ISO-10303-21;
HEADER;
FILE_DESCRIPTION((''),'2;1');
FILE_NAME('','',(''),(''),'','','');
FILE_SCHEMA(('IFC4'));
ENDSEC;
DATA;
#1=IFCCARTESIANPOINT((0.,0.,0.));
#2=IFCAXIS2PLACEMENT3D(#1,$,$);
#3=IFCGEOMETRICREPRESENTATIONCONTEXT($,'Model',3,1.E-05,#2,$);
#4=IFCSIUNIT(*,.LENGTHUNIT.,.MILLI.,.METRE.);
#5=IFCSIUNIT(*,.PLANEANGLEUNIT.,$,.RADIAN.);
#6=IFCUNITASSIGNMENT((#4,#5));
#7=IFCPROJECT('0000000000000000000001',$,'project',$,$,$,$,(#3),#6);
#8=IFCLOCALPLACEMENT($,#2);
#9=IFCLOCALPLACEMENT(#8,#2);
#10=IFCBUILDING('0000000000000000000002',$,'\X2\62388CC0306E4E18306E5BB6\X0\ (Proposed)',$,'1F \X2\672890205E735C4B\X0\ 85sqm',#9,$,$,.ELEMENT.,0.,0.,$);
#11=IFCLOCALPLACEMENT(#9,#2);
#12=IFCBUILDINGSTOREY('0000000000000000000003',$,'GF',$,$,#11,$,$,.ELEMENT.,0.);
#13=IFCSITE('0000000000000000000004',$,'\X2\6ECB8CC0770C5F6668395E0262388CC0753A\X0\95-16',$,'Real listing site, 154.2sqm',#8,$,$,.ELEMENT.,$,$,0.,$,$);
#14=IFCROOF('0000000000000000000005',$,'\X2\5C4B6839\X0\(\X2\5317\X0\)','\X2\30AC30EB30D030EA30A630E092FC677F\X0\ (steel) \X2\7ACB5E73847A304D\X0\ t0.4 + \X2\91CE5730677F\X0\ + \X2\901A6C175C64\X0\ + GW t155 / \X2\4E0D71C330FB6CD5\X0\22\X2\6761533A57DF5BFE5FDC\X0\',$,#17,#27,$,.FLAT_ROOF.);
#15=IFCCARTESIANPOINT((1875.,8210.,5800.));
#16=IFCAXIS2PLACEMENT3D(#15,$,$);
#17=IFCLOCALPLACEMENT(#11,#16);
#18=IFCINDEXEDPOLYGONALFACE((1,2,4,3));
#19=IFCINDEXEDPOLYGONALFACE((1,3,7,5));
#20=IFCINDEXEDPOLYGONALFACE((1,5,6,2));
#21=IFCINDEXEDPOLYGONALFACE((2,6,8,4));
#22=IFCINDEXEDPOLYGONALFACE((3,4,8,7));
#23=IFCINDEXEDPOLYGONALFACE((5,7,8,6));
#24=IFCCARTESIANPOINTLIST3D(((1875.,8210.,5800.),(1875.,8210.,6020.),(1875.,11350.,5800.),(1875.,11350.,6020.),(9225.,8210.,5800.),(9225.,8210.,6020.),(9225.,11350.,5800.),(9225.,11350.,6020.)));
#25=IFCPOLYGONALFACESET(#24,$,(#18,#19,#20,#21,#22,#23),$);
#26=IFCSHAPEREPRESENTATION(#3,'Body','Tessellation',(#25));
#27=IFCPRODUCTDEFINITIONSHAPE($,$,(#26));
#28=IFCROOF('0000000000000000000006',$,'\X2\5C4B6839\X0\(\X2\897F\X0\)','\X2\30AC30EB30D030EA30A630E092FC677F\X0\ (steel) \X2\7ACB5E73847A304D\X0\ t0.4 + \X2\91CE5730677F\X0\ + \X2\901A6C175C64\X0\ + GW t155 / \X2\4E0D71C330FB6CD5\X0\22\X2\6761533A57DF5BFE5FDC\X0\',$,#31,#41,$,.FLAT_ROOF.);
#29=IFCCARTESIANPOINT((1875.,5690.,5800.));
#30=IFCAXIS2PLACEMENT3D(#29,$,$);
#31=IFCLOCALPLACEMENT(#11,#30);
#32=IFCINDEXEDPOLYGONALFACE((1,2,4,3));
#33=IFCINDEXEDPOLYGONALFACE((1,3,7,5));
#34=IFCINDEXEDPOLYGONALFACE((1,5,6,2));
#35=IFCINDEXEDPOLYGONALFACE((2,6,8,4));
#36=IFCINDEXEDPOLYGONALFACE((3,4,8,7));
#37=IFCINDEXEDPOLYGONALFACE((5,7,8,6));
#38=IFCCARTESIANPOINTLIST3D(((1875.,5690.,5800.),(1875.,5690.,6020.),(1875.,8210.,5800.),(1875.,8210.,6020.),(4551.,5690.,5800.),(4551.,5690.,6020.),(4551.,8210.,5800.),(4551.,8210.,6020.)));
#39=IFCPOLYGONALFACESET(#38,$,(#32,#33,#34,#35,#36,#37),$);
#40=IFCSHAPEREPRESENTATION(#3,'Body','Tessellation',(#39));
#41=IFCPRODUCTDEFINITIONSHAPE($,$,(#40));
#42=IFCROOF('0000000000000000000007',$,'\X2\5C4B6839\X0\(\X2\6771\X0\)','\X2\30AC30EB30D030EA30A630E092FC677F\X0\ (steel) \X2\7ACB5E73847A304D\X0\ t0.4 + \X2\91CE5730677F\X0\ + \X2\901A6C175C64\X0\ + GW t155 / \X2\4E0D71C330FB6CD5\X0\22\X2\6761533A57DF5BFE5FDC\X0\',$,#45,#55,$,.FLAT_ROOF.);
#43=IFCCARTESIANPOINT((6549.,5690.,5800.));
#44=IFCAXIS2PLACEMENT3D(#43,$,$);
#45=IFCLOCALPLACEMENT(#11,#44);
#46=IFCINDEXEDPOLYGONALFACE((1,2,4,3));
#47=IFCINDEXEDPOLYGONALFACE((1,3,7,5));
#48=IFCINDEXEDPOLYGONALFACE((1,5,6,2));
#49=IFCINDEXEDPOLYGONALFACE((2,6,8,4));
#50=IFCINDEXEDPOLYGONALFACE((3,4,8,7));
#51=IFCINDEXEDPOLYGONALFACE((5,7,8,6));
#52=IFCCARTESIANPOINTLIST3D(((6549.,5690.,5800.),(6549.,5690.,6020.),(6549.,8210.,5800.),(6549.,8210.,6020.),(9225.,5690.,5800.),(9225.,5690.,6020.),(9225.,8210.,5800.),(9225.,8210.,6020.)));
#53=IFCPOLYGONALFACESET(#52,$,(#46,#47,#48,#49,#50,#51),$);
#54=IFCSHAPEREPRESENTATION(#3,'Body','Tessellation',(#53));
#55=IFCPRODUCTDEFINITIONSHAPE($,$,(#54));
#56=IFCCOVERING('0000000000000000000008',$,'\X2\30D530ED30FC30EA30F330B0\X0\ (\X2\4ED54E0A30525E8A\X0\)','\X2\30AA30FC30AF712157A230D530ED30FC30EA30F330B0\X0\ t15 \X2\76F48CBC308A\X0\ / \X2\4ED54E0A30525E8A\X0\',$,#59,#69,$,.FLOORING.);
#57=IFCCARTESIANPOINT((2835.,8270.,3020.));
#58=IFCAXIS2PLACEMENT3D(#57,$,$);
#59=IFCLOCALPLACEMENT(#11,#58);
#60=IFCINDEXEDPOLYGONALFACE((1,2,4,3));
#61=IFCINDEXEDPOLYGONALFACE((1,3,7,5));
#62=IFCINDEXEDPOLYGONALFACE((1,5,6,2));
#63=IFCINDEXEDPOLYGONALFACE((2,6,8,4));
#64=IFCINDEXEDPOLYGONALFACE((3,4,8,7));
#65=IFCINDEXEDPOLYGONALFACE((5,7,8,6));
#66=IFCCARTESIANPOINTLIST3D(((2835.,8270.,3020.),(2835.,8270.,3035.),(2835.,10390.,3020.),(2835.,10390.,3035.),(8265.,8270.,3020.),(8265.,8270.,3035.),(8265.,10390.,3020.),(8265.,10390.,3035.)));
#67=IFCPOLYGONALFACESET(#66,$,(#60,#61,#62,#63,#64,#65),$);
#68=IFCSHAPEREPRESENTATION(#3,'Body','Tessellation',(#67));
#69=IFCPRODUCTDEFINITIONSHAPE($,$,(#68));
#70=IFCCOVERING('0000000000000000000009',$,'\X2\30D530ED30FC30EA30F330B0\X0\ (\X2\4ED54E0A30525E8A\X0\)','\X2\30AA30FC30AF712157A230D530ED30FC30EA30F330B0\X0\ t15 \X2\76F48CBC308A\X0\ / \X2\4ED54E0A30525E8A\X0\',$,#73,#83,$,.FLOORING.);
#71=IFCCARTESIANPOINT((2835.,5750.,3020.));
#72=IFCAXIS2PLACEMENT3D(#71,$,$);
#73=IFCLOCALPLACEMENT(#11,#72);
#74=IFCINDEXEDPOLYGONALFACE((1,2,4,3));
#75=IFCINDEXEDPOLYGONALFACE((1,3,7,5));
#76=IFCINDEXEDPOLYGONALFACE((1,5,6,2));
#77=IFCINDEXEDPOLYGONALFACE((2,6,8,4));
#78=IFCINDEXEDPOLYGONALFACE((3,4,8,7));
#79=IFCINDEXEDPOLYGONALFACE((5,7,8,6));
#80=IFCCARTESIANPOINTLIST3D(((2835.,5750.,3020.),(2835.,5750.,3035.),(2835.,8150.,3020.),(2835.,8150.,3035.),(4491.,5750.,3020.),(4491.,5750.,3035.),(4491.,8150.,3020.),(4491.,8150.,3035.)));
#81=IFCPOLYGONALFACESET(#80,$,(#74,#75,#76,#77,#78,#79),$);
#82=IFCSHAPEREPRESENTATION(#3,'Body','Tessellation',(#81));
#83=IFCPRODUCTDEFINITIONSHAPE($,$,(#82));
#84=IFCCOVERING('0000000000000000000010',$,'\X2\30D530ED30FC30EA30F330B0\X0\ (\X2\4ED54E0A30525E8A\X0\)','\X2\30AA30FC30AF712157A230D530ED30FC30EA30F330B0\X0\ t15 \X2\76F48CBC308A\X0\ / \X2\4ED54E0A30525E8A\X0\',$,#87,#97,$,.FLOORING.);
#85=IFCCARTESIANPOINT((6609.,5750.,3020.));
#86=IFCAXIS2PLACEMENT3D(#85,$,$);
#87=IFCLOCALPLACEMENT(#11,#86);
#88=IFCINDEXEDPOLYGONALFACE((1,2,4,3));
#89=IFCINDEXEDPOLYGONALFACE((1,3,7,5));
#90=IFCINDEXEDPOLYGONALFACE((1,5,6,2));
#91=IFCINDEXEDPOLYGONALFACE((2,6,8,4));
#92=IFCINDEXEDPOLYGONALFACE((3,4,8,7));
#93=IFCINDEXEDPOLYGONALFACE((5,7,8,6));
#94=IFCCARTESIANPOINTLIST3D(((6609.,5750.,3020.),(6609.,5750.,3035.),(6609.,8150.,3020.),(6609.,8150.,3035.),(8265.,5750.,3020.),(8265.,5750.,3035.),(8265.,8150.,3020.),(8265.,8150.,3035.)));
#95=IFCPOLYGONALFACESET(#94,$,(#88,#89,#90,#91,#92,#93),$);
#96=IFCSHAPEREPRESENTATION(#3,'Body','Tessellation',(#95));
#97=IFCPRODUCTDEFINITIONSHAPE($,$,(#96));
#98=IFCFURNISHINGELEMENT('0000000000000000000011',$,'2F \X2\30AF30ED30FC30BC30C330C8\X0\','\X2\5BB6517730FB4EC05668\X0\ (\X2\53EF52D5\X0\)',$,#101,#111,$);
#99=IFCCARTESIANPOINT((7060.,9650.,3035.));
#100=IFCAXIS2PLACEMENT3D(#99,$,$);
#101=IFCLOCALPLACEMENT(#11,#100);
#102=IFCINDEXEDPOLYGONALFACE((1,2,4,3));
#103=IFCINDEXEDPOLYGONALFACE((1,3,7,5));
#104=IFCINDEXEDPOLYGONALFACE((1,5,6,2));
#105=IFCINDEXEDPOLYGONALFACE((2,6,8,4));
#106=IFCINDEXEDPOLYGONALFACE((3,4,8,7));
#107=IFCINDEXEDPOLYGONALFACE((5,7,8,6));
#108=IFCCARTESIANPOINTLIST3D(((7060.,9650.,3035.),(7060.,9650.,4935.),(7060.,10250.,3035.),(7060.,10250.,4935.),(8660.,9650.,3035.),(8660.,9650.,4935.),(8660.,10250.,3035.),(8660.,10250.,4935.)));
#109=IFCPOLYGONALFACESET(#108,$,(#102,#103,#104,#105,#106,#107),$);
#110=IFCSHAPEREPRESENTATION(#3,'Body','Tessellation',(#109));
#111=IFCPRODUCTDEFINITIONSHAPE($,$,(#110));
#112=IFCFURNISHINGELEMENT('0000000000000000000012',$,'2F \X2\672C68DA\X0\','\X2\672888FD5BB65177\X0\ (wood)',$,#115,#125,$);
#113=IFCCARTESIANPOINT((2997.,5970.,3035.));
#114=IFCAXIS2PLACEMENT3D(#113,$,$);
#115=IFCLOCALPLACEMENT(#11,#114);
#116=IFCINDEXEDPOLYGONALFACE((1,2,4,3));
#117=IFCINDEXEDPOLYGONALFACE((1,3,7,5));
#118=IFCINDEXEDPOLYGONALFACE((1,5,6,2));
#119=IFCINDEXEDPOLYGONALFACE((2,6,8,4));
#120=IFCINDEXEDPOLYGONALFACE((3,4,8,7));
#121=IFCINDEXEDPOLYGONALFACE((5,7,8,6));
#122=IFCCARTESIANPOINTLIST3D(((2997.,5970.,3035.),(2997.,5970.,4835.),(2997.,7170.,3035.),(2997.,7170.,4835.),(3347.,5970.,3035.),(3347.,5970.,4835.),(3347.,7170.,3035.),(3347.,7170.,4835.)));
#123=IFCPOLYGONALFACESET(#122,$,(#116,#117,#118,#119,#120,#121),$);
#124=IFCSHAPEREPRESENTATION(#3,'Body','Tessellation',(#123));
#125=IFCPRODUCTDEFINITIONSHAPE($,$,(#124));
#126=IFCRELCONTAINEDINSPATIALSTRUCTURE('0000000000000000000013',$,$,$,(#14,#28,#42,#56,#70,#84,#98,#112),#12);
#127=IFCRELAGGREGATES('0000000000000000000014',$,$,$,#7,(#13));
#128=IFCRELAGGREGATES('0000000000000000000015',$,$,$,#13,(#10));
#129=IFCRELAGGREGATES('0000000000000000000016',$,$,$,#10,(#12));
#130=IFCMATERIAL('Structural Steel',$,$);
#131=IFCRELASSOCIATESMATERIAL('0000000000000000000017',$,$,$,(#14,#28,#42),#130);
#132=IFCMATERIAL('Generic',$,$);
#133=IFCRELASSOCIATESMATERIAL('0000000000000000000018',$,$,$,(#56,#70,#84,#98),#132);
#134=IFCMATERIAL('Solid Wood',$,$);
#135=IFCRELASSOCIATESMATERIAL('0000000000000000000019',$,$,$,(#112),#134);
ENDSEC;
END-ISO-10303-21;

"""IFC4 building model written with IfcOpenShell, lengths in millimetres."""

from ifc_helpers import new_model, si_unit, frame, frame_2d, origin, place, context, project, spatial, rectangle, extrude, material, element, save


model = new_model("IFC4")

# Units and contexts
model_context = context("Model", 3, precision=1e-05, world=origin())
ifc_project = project(units=[si_unit("LENGTHUNIT", "METRE", prefix="MILLI"), si_unit("PLANEANGLEUNIT", "RADIAN")], contexts=[model_context])

# Site, building, storey
site_placement = place(None, origin())
site = spatial("IfcSite", under=ifc_project, at=site_placement, Name="滋賀県彦根市戸賀町95-16", ObjectType="Real listing site, 154.2sqm", CompositionType="ELEMENT", RefElevation=0.0)
building_placement = place(site_placement, origin())
building = spatial("IfcBuilding", under=site, at=building_placement, Name="戸賀の丘の家 (Proposed)", ObjectType="1F 木造平屋 85sqm", CompositionType="ELEMENT", ElevationOfRefHeight=0.0, ElevationOfTerrain=0.0)
storey_placement = place(building_placement, origin())
storey = spatial("IfcBuildingStorey", under=building, at=storey_placement, Name="GF", CompositionType="ELEMENT", Elevation=0.0)

# Shared definitions
ifc_material_1 = material(Name="Solid Wood")

# Shared definitions
ifc_material_2 = material(Name="Generic")

# Roofs
ifc_material_3 = material(Name="Structural Steel")
for number, where, name in (
    (1, (1875.0, 8210.0, 5800.0), "屋根(北)"),
):
    element("IfcRoof", number, at=place(storey_placement, frame(where)), inside=storey, material=ifc_material_3, Name=name, Description="ガルバリウム鋼板 (steel) 立平葺き t0.4 + 野地板 + 通気層 + GW t155 / 不燃・法22条区域対応", PredefinedType="FLAT_ROOF", context=model_context, shape_type="SweptSolid", body=[
        extrude(rectangle(XDim=7350.0, YDim=3140.0, at=frame_2d((3675.0, 1570.0))), frame((1875.0, 8210.0, 5800.0)), (0.0, 0.0, 1.0), 220.0),
    ])
roof_1_placement = place(storey_placement, frame((1875.0, 5690.0, 5800.0)))
element("IfcRoof", 2, at=roof_1_placement, inside=storey, material=ifc_material_3, Name="屋根(西)", Description="ガルバリウム鋼板 (steel) 立平葺き t0.4 + 野地板 + 通気層 + GW t155 / 不燃・法22条区域対応", PredefinedType="FLAT_ROOF", context=model_context, shape_type="SweptSolid", body=[
    extrude(rectangle(XDim=2676.0, YDim=2520.0, at=frame_2d((1338.0, 1260.0))), frame((1875.0, 5690.0, 5800.0)), (0.0, 0.0, 1.0), 220.0),
])
roof_2_placement = place(storey_placement, frame((6549.0, 5690.0, 5800.0)))
element("IfcRoof", 3, at=roof_2_placement, inside=storey, material=ifc_material_3, Name="屋根(東)", Description="ガルバリウム鋼板 (steel) 立平葺き t0.4 + 野地板 + 通気層 + GW t155 / 不燃・法22条区域対応", PredefinedType="FLAT_ROOF", context=model_context, shape_type="SweptSolid", body=[
    extrude(rectangle(XDim=2676.0, YDim=2520.0, at=frame_2d((1338.0, 1260.0))), frame((6549.0, 5690.0, 5800.0)), (0.0, 0.0, 1.0), 220.0),
])

# Coverings
covering_1_placement = place(storey_placement, frame((2835.0, 8270.0, 3020.0)))
element("IfcCovering", 4, at=covering_1_placement, inside=storey, material=ifc_material_2, Name="フローリング (仕上げ床)", Description="オーク無垢フローリング t15 直貼り / 仕上げ床", PredefinedType="FLOORING", context=model_context, shape_type="SweptSolid", body=[
    extrude(rectangle(XDim=5430.0, YDim=2120.0, at=frame_2d((2715.0, 1060.0))), frame((2835.0, 8270.0, 3020.0)), (0.0, 0.0, 1.0), 15.0),
])
covering_2_placement = place(storey_placement, frame((2835.0, 5750.0, 3020.0)))
element("IfcCovering", 5, at=covering_2_placement, inside=storey, material=ifc_material_2, Name="フローリング (仕上げ床)", Description="オーク無垢フローリング t15 直貼り / 仕上げ床", PredefinedType="FLOORING", context=model_context, shape_type="SweptSolid", body=[
    extrude(rectangle(XDim=1656.0, YDim=2400.0, at=frame_2d((828.0, 1200.0))), frame((2835.0, 5750.0, 3020.0)), (0.0, 0.0, 1.0), 15.0),
])
covering_3_placement = place(storey_placement, frame((6609.0, 5750.0, 3020.0)))
element("IfcCovering", 6, at=covering_3_placement, inside=storey, material=ifc_material_2, Name="フローリング (仕上げ床)", Description="オーク無垢フローリング t15 直貼り / 仕上げ床", PredefinedType="FLOORING", context=model_context, shape_type="SweptSolid", body=[
    extrude(rectangle(XDim=1656.0, YDim=2400.0, at=frame_2d((828.0, 1200.0))), frame((6609.0, 5750.0, 3020.0)), (0.0, 0.0, 1.0), 15.0),
])

# Furnishing elements
furnishing_1_placement = place(storey_placement, frame((7060.0, 9650.0, 3035.0)))
element("IfcFurnishingElement", 7, at=furnishing_1_placement, inside=storey, material=ifc_material_2, Name="2F クローゼット", Description="家具・什器 (可動)", context=model_context, shape_type="SweptSolid", body=[
    extrude(rectangle(XDim=1600.0, YDim=600.0, at=frame_2d((800.0, 300.0))), frame((7060.0, 9650.0, 3035.0)), (0.0, 0.0, 1.0), 1900.0),
])
furnishing_2_placement = place(storey_placement, frame((2997.0, 5970.0, 3035.0)))
element("IfcFurnishingElement", 8, at=furnishing_2_placement, inside=storey, material=ifc_material_1, Name="2F 本棚", Description="木製家具 (wood)", context=model_context, shape_type="SweptSolid", body=[
    extrude(rectangle(XDim=350.0, YDim=1200.0, at=frame_2d((175.0, 600.0))), frame((2997.0, 5970.0, 3035.0)), (0.0, 0.0, 1.0), 1800.0),
])

save(model, "model.ifc")
